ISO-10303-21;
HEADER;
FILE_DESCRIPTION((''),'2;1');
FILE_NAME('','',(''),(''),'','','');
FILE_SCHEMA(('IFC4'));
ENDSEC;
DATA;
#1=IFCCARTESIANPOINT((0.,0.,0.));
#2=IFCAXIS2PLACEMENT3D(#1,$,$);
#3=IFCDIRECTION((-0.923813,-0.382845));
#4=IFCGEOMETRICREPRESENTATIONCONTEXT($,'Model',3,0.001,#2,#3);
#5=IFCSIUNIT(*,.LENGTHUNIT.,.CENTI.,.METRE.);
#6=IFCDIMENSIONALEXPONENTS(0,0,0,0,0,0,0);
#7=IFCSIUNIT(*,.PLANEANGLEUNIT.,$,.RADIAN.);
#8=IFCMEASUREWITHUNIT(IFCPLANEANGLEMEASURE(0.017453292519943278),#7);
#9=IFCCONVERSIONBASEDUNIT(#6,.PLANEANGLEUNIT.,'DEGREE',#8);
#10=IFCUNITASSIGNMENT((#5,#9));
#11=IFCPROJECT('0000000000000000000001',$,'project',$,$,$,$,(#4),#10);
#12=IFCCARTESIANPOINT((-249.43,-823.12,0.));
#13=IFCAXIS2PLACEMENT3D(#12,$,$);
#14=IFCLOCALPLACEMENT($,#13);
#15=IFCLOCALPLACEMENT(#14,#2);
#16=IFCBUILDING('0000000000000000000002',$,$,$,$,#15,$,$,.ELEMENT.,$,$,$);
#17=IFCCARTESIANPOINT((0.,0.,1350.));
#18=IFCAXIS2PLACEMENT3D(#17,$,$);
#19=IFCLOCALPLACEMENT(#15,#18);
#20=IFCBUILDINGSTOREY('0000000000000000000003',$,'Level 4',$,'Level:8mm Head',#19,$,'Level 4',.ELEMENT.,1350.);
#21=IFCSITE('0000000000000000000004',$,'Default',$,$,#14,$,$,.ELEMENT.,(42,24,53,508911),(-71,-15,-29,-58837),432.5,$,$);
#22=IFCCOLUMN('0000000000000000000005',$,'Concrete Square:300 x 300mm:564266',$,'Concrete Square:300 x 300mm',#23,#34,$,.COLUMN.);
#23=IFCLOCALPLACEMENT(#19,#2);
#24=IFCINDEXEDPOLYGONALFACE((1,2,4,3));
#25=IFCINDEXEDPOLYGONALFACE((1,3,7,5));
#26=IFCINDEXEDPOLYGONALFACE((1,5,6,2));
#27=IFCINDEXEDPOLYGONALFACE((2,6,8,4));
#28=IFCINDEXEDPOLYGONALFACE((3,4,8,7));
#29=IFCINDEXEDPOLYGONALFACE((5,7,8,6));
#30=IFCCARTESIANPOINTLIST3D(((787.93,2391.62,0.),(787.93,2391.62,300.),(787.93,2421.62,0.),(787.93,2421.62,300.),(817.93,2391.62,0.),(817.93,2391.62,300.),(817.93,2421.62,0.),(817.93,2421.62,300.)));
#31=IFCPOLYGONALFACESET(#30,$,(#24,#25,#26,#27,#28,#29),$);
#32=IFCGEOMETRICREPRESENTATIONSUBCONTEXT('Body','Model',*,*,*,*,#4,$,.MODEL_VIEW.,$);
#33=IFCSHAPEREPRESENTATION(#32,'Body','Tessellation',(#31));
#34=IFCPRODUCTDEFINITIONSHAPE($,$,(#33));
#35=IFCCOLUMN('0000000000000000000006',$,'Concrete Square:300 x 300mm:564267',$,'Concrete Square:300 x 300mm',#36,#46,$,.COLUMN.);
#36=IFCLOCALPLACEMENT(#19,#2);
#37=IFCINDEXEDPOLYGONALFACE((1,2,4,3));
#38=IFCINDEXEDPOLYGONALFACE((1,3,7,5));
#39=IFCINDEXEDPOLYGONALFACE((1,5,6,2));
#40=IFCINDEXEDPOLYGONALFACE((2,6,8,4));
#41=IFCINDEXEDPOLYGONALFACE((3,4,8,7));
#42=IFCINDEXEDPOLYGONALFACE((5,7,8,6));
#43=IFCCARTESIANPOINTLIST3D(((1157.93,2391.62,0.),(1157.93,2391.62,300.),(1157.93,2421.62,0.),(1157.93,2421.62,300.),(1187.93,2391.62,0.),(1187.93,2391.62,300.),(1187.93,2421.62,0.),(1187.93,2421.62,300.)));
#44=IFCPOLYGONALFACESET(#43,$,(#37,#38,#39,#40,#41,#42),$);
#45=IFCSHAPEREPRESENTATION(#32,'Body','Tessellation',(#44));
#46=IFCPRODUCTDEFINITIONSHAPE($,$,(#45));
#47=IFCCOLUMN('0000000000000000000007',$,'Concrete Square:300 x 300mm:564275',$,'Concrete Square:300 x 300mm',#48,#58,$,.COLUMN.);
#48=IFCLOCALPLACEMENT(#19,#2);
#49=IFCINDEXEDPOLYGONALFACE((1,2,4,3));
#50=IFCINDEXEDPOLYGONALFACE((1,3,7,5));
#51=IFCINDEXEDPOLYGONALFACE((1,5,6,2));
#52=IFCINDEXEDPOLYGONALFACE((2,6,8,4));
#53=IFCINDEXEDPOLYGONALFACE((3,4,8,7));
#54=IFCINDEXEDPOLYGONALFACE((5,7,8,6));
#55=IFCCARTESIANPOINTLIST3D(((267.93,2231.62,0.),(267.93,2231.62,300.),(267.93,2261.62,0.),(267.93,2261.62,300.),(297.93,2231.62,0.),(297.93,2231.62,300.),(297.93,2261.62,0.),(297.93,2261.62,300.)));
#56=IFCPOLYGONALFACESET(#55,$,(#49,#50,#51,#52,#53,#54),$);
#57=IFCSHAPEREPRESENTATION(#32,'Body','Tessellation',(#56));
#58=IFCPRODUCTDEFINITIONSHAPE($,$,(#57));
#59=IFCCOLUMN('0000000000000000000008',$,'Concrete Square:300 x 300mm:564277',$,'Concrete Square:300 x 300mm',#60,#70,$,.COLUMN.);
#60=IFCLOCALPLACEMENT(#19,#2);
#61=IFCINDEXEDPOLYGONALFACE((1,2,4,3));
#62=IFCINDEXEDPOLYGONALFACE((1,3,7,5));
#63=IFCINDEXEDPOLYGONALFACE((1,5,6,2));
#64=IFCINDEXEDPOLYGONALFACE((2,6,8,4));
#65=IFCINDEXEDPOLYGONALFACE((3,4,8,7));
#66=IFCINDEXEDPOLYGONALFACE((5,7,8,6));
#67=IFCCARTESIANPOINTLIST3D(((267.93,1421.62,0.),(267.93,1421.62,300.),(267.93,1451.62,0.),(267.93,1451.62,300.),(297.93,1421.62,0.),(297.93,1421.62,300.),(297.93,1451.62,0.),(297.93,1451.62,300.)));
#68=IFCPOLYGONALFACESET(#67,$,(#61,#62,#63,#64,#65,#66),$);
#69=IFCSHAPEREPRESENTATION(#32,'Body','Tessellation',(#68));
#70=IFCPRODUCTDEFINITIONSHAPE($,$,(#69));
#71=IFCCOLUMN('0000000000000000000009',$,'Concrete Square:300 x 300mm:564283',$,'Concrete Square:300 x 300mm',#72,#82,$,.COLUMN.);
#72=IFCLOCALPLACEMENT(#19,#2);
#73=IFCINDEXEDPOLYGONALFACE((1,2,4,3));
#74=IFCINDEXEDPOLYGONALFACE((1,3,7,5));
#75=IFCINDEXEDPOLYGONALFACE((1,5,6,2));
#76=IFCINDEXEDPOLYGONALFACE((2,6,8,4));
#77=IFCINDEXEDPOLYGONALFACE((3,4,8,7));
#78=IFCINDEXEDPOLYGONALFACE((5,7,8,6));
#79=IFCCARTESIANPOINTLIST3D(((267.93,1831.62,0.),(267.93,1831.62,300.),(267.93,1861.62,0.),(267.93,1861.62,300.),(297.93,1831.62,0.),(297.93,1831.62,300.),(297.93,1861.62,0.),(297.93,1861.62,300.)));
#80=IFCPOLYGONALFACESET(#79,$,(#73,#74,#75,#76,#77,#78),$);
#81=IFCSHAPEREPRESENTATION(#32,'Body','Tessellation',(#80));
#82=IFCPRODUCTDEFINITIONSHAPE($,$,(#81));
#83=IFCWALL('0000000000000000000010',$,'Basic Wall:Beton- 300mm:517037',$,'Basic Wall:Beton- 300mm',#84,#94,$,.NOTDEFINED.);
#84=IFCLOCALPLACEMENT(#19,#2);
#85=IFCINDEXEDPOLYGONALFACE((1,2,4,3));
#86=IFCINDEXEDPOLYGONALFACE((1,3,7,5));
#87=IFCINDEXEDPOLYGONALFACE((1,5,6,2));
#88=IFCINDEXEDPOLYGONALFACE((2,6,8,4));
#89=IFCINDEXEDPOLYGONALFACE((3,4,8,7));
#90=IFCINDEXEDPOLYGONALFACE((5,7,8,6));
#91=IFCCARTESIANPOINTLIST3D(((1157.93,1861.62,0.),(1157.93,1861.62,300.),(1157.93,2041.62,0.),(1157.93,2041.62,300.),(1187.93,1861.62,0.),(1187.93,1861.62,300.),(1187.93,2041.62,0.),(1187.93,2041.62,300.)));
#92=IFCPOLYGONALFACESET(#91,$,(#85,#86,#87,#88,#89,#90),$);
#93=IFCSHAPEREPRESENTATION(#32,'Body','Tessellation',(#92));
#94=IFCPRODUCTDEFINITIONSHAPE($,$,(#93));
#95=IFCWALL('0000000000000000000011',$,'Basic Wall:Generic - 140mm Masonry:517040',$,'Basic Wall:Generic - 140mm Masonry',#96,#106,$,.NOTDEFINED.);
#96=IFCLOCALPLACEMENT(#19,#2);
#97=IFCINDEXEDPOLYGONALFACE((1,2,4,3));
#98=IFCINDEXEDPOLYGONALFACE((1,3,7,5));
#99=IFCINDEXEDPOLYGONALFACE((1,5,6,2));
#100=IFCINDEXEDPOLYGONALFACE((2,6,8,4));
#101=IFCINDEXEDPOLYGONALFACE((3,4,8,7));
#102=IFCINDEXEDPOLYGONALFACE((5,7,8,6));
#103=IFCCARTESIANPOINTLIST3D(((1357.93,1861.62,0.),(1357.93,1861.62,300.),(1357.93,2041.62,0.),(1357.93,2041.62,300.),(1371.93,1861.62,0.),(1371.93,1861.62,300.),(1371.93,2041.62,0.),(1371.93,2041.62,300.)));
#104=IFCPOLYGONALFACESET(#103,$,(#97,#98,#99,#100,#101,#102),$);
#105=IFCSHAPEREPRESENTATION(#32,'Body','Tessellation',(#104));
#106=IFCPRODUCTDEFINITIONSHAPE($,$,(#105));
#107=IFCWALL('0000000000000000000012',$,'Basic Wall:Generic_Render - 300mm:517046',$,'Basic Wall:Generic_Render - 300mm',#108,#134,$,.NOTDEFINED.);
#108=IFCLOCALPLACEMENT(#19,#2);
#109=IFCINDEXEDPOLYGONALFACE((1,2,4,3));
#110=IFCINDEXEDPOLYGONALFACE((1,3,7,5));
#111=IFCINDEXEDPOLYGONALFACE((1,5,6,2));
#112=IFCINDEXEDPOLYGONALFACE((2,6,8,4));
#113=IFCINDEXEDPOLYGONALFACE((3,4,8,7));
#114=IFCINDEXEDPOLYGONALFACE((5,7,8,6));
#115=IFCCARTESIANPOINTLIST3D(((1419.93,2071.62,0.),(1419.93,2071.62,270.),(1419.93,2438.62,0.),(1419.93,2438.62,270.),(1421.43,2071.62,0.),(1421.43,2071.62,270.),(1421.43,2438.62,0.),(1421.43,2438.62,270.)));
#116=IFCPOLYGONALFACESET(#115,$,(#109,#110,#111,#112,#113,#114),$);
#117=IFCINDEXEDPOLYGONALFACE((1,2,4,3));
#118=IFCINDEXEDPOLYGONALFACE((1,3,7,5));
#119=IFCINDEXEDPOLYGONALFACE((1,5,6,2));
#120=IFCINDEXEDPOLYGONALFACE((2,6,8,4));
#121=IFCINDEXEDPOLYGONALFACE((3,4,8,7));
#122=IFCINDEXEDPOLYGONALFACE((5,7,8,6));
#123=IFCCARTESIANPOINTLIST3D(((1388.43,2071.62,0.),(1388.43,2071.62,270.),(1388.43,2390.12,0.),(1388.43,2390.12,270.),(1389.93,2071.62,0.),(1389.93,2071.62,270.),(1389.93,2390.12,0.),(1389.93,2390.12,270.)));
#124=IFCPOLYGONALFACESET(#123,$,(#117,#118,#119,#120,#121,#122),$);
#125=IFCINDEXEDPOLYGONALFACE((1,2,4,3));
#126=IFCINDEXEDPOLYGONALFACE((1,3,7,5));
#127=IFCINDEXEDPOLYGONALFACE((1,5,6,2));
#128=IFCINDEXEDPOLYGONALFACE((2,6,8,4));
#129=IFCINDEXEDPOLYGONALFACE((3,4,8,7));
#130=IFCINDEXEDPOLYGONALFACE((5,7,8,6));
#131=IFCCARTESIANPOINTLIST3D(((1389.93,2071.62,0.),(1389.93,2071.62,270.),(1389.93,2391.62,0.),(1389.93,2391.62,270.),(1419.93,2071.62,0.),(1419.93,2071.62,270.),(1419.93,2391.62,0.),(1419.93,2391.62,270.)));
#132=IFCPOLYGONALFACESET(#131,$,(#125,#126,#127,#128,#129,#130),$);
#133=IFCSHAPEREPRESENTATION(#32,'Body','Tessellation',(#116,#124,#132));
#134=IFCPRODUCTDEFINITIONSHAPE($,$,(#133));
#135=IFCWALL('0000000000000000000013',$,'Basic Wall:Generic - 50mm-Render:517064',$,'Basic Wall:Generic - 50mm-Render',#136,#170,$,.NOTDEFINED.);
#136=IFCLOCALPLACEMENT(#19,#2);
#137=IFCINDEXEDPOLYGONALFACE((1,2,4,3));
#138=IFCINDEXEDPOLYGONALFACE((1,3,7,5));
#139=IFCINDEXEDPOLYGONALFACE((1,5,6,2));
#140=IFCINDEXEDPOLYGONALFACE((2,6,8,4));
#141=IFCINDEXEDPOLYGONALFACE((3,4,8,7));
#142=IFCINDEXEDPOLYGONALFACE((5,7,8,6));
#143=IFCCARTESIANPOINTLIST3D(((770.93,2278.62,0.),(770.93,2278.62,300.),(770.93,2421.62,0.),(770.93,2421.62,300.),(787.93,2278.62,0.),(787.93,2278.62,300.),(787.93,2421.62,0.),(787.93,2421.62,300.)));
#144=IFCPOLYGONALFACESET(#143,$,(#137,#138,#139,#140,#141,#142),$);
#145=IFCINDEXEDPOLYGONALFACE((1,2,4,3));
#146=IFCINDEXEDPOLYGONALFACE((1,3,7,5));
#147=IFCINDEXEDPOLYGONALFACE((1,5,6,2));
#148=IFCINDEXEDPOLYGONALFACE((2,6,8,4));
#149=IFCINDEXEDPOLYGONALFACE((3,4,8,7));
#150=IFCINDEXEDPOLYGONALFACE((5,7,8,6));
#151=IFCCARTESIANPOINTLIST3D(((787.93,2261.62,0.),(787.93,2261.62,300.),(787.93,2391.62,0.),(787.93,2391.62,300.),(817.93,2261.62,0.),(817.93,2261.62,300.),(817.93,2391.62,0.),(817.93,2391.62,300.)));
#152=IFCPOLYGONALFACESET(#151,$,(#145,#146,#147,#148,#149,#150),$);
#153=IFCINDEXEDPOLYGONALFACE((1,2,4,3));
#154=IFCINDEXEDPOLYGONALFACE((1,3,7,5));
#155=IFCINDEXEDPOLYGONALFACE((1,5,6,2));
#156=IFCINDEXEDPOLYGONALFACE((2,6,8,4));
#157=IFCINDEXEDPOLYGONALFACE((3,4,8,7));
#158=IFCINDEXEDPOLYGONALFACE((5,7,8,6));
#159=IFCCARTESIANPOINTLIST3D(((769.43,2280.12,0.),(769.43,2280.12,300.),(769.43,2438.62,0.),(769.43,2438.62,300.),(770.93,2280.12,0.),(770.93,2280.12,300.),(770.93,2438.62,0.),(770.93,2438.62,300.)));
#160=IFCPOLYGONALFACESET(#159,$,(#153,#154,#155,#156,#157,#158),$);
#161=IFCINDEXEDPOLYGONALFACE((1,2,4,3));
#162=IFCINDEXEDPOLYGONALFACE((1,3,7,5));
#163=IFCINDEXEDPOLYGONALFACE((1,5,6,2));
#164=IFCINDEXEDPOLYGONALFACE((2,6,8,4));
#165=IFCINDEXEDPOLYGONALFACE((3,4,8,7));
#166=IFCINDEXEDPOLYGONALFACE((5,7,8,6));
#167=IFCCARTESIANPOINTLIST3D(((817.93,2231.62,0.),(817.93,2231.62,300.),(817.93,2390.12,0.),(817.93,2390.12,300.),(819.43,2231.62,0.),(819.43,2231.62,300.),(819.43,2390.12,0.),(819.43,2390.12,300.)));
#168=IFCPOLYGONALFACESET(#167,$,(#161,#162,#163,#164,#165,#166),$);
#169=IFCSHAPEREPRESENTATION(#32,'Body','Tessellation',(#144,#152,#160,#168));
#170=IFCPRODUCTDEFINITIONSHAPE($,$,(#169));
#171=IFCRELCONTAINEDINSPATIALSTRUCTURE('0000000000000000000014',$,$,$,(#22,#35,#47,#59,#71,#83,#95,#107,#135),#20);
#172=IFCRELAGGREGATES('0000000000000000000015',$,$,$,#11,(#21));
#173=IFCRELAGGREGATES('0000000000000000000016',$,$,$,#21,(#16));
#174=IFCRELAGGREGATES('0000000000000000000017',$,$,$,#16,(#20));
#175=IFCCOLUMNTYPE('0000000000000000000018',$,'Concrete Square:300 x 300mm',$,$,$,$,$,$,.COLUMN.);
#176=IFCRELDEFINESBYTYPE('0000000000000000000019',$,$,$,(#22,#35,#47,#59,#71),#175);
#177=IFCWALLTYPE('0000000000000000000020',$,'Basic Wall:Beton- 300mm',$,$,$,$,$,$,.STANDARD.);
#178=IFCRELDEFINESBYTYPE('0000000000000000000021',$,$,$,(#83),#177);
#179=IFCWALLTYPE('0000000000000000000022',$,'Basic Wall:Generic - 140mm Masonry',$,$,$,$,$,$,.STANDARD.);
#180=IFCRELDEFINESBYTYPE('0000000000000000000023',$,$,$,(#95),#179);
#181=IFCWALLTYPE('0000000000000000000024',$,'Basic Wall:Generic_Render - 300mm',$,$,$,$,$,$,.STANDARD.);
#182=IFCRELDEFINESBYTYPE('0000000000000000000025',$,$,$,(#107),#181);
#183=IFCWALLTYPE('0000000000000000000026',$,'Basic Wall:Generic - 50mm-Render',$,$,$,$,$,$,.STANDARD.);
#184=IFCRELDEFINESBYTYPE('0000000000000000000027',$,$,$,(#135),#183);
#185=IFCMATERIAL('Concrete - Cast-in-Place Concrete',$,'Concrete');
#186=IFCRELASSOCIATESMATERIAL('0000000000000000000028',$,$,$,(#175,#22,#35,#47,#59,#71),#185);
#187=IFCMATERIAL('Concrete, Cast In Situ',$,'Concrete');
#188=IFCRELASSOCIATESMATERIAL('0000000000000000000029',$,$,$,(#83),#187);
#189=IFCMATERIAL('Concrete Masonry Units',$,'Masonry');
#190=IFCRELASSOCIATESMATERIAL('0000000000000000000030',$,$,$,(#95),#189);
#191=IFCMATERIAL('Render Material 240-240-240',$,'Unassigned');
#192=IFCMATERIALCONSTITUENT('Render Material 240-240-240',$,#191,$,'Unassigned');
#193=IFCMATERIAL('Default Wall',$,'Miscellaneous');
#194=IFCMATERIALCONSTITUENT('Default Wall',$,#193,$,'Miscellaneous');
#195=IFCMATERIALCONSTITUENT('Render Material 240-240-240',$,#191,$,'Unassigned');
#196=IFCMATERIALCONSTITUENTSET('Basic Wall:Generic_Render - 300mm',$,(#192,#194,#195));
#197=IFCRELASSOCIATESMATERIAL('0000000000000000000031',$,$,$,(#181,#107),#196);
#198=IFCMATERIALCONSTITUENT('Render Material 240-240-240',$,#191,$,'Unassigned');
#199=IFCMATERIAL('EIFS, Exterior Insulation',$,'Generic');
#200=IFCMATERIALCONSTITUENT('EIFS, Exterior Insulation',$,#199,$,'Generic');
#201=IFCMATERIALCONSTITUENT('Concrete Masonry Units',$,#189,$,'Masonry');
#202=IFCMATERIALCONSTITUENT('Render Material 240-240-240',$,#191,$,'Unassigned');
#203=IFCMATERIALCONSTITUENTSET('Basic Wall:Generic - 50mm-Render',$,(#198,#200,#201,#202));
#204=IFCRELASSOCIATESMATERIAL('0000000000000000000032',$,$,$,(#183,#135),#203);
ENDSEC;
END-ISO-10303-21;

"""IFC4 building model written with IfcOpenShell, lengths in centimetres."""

from ifc_helpers import new_model, entity, si_unit, converted_unit, direction, frame, origin, place, context, subcontext, project, spatial, indexed_curve, outline, extrude, source, transform, mapped, material, constituent, constituent_set, type_object, type_shapes, element, save


model = new_model("IFC4")

# Units and contexts
model_context = context("Model", 3, precision=0.001, world=origin(), true_north=direction((-0.923813, -0.382845)))
body_context = subcontext(model_context, "Body", "Model", "MODEL_VIEW")
ifc_project = project(units=[si_unit("LENGTHUNIT", "METRE", prefix="CENTI"), converted_unit("PLANEANGLEUNIT", "DEGREE", entity("IfcPlaneAngleMeasure", 0.017453292519943278), si_unit("PLANEANGLEUNIT", "RADIAN"), dimensions=[0, 0, 0, 0, 0, 0, 0])], contexts=[model_context])

# Site, building, storey
site_placement = place(None, frame((-249.43, -823.12, 0.0)))
site = spatial("IfcSite", under=ifc_project, at=site_placement, Name="Default", CompositionType="ELEMENT", RefLatitude=(42, 24, 53, 508911), RefLongitude=(-71, -15, -29, -58837), RefElevation=432.5)
building_placement = place(site_placement, origin())
building = spatial("IfcBuilding", under=site, at=building_placement, CompositionType="ELEMENT")
storey_placement = place(building_placement, frame((0.0, 0.0, 1350.0)))
storey = spatial("IfcBuildingStorey", under=building, at=storey_placement, Name="Level 4", ObjectType="Level:8mm Head", LongName="Level 4", CompositionType="ELEMENT", Elevation=1350.0)

# Columns
ifc_material_1 = material(Name="Concrete - Cast-in-Place Concrete", Category="Concrete")
column_type = type_object("IfcColumnType", Name="Concrete Square:300 x 300mm", PredefinedType="COLUMN", material=ifc_material_1)
shared_shape_1 = source(origin(), body_context, "Body", "SweptSolid", [
    extrude(outline(indexed_curve([(-15.0, -15.0), (15.0, -15.0), (15.0, 15.0), (-15.0, 15.0), (-15.0, -15.0)], self_intersect=False)), frame((0.0, 0.0, 1350.0), z_axis=(0.0, 0.0, 1.0), x_axis=(-1.0, 0.0, 0.0)), (0.0, 0.0, 1.0), 300.0),
])
type_shapes(column_type, [shared_shape_1])
for number, where, name in (
    (1, (802.93, 2406.62, -1350.0), "Concrete Square:300 x 300mm:564266"),
    (2, (1172.93, 2406.62, -1350.0), "Concrete Square:300 x 300mm:564267"),
    (3, (282.93, 2246.62, -1350.0), "Concrete Square:300 x 300mm:564275"),
    (4, (282.93, 1436.62, -1350.0), "Concrete Square:300 x 300mm:564277"),
    (5, (282.93, 1846.62, -1350.0), "Concrete Square:300 x 300mm:564283"),
):
    element("IfcColumn", number, at=place(storey_placement, frame(where)), inside=storey, type_object=column_type, material=ifc_material_1, Name=name, ObjectType="Concrete Square:300 x 300mm", PredefinedType="COLUMN", context=body_context, shape_type="MappedRepresentation", body=[
        mapped(shared_shape_1, transform((0.0, 0.0, 0.0), scale=1.0)),
    ])

# Walls
ifc_material_2 = material(Name="Concrete, Cast In Situ", Category="Concrete")
wall_type_1 = type_object("IfcWallType", Name="Basic Wall:Beton- 300mm", PredefinedType="STANDARD")
wall_1_placement = place(storey_placement, frame((1172.93, 2041.62, 0.0), z_axis=(0.0, 0.0, 1.0), x_axis=(0.0, -1.0, 0.0)))
element("IfcWall", 6, at=wall_1_placement, inside=storey, type_object=wall_type_1, material=ifc_material_2, Name="Basic Wall:Beton- 300mm:517037", ObjectType="Basic Wall:Beton- 300mm", PredefinedType="NOTDEFINED", context=body_context, shape_type="SweptSolid", body=[
    extrude(outline(indexed_curve([(180.0, 15.0), (0.0, 15.0), (0.0, -15.0), (180.0, -15.0), (180.0, 15.0)], self_intersect=False)), origin(), (0.0, 0.0, 1.0), 300.0),
])
ifc_material_3 = material(Name="Concrete Masonry Units", Category="Masonry")
wall_type_2 = type_object("IfcWallType", Name="Basic Wall:Generic - 140mm Masonry", PredefinedType="STANDARD")
wall_2_placement = place(storey_placement, frame((1364.93, 2041.62, 0.0), z_axis=(0.0, 0.0, 1.0), x_axis=(0.0, -1.0, 0.0)))
element("IfcWall", 7, at=wall_2_placement, inside=storey, type_object=wall_type_2, material=ifc_material_3, Name="Basic Wall:Generic - 140mm Masonry:517040", ObjectType="Basic Wall:Generic - 140mm Masonry", PredefinedType="NOTDEFINED", context=body_context, shape_type="SweptSolid", body=[
    extrude(outline(indexed_curve([(180.0, 7.0), (0.0, 7.0), (0.0, -7.0), (180.0, -7.0), (180.0, 7.0)], self_intersect=False)), origin(), (0.0, 0.0, 1.0), 300.0),
])
ifc_material_4 = material(Name="Render Material 240-240-240", Category="Unassigned")
ifc_constituent_1 = constituent(ifc_material_4, Name="Render Material 240-240-240", Category="Unassigned")
ifc_material_5 = material(Name="Default Wall", Category="Miscellaneous")
ifc_constituent_2 = constituent(ifc_material_5, Name="Default Wall", Category="Miscellaneous")
ifc_constituent_3 = constituent(ifc_material_4, Name="Render Material 240-240-240", Category="Unassigned")
ifc_constituent_set_1 = constituent_set(constituents=[ifc_constituent_1, ifc_constituent_2, ifc_constituent_3], Name="Basic Wall:Generic_Render - 300mm")
wall_type_3 = type_object("IfcWallType", Name="Basic Wall:Generic_Render - 300mm", PredefinedType="STANDARD", material=ifc_constituent_set_1)
wall_3_placement = place(storey_placement, frame((1404.93, 2071.62, 0.0), z_axis=(0.0, 0.0, 1.0), x_axis=(0.0, 1.0, 0.0)))
element("IfcWall", 8, at=wall_3_placement, inside=storey, type_object=wall_type_3, material=ifc_constituent_set_1, Name="Basic Wall:Generic_Render - 300mm:517046", ObjectType="Basic Wall:Generic_Render - 300mm", PredefinedType="NOTDEFINED", context=body_context, shape_type="SweptSolid", body=[
    extrude(outline(indexed_curve([(-0.75, -183.5), (0.75, -183.5), (0.75, 183.5), (-0.75, 183.5), (-0.75, -183.5)], self_intersect=False)), frame((183.5, -15.75, 0.0), z_axis=(0.0, 0.0, 1.0), x_axis=(0.0, 1.0, 0.0)), (0.0, 0.0, 1.0), 270.0),
    extrude(outline(indexed_curve([(-0.75, -159.25), (0.75, -159.25), (0.75, 159.25), (-0.75, 159.25), (-0.75, -159.25)], self_intersect=False)), frame((159.25, 15.75, 0.0), z_axis=(0.0, 0.0, 1.0), x_axis=(0.0, -1.0, 0.0)), (0.0, 0.0, 1.0), 270.0),
    extrude(outline(indexed_curve([(-160.0, -15.0), (160.0, -15.0), (160.0, 15.0), (-160.0, 15.0), (-160.0, -15.0)], self_intersect=False)), frame((160.0, 0.0, 0.0)), (0.0, 0.0, 1.0), 270.0),
])
ifc_constituent_4 = constituent(ifc_material_4, Name="Render Material 240-240-240", Category="Unassigned")
ifc_material_6 = material(Name="EIFS, Exterior Insulation", Category="Generic")
ifc_constituent_5 = constituent(ifc_material_6, Name="EIFS, Exterior Insulation", Category="Generic")
ifc_constituent_6 = constituent(ifc_material_3, Name="Concrete Masonry Units", Category="Masonry")
ifc_constituent_7 = constituent(ifc_material_4, Name="Render Material 240-240-240", Category="Unassigned")
ifc_constituent_set_2 = constituent_set(constituents=[ifc_constituent_4, ifc_constituent_5, ifc_constituent_6, ifc_constituent_7], Name="Basic Wall:Generic - 50mm-Render")
wall_type_4 = type_object("IfcWallType", Name="Basic Wall:Generic - 50mm-Render", PredefinedType="STANDARD", material=ifc_constituent_set_2)
wall_4_placement = place(storey_placement, frame((794.43, 2280.12, 0.0), z_axis=(0.0, 0.0, 1.0), x_axis=(0.0, 1.0, 0.0)))
element("IfcWall", 9, at=wall_4_placement, inside=storey, type_object=wall_type_4, material=ifc_constituent_set_2, Name="Basic Wall:Generic - 50mm-Render:517064", ObjectType="Basic Wall:Generic - 50mm-Render", PredefinedType="NOTDEFINED", context=body_context, shape_type="SweptSolid", body=[
    extrude(outline(indexed_curve([(-8.5, -71.5), (8.5, -71.5), (8.5, 71.5), (-8.5, 71.5), (-8.5, -71.5)], self_intersect=False)), frame((70.0, 15.0, 0.0), z_axis=(0.0, 0.0, 1.0), x_axis=(0.0, -1.0, 0.0)), (0.0, 0.0, 1.0), 300.0),
    extrude(outline(indexed_curve([(-15.0, -65.0), (15.0, -65.0), (15.0, 65.0), (-15.0, 65.0), (-15.0, -65.0)], self_intersect=False)), frame((46.5, -8.5, 0.0), z_axis=(0.0, 0.0, 1.0), x_axis=(0.0, 1.0, 0.0)), (0.0, 0.0, 1.0), 300.0),
    extrude(outline(indexed_curve([(-0.75, -79.25), (0.75, -79.25), (0.75, 79.25), (-0.75, 79.25), (-0.75, -79.25)], self_intersect=False)), frame((79.25, 24.25, 0.0), z_axis=(0.0, 0.0, 1.0), x_axis=(0.0, -1.0, 0.0)), (0.0, 0.0, 1.0), 300.0),
    extrude(outline(indexed_curve([(-0.75, -79.25), (0.75, -79.25), (0.75, 79.25), (-0.75, 79.25), (-0.75, -79.25)], self_intersect=False)), frame((30.75, -24.25, 0.0), z_axis=(0.0, 0.0, 1.0), x_axis=(0.0, -1.0, 0.0)), (0.0, 0.0, 1.0), 300.0),
])

save(model, "model.ifc")
